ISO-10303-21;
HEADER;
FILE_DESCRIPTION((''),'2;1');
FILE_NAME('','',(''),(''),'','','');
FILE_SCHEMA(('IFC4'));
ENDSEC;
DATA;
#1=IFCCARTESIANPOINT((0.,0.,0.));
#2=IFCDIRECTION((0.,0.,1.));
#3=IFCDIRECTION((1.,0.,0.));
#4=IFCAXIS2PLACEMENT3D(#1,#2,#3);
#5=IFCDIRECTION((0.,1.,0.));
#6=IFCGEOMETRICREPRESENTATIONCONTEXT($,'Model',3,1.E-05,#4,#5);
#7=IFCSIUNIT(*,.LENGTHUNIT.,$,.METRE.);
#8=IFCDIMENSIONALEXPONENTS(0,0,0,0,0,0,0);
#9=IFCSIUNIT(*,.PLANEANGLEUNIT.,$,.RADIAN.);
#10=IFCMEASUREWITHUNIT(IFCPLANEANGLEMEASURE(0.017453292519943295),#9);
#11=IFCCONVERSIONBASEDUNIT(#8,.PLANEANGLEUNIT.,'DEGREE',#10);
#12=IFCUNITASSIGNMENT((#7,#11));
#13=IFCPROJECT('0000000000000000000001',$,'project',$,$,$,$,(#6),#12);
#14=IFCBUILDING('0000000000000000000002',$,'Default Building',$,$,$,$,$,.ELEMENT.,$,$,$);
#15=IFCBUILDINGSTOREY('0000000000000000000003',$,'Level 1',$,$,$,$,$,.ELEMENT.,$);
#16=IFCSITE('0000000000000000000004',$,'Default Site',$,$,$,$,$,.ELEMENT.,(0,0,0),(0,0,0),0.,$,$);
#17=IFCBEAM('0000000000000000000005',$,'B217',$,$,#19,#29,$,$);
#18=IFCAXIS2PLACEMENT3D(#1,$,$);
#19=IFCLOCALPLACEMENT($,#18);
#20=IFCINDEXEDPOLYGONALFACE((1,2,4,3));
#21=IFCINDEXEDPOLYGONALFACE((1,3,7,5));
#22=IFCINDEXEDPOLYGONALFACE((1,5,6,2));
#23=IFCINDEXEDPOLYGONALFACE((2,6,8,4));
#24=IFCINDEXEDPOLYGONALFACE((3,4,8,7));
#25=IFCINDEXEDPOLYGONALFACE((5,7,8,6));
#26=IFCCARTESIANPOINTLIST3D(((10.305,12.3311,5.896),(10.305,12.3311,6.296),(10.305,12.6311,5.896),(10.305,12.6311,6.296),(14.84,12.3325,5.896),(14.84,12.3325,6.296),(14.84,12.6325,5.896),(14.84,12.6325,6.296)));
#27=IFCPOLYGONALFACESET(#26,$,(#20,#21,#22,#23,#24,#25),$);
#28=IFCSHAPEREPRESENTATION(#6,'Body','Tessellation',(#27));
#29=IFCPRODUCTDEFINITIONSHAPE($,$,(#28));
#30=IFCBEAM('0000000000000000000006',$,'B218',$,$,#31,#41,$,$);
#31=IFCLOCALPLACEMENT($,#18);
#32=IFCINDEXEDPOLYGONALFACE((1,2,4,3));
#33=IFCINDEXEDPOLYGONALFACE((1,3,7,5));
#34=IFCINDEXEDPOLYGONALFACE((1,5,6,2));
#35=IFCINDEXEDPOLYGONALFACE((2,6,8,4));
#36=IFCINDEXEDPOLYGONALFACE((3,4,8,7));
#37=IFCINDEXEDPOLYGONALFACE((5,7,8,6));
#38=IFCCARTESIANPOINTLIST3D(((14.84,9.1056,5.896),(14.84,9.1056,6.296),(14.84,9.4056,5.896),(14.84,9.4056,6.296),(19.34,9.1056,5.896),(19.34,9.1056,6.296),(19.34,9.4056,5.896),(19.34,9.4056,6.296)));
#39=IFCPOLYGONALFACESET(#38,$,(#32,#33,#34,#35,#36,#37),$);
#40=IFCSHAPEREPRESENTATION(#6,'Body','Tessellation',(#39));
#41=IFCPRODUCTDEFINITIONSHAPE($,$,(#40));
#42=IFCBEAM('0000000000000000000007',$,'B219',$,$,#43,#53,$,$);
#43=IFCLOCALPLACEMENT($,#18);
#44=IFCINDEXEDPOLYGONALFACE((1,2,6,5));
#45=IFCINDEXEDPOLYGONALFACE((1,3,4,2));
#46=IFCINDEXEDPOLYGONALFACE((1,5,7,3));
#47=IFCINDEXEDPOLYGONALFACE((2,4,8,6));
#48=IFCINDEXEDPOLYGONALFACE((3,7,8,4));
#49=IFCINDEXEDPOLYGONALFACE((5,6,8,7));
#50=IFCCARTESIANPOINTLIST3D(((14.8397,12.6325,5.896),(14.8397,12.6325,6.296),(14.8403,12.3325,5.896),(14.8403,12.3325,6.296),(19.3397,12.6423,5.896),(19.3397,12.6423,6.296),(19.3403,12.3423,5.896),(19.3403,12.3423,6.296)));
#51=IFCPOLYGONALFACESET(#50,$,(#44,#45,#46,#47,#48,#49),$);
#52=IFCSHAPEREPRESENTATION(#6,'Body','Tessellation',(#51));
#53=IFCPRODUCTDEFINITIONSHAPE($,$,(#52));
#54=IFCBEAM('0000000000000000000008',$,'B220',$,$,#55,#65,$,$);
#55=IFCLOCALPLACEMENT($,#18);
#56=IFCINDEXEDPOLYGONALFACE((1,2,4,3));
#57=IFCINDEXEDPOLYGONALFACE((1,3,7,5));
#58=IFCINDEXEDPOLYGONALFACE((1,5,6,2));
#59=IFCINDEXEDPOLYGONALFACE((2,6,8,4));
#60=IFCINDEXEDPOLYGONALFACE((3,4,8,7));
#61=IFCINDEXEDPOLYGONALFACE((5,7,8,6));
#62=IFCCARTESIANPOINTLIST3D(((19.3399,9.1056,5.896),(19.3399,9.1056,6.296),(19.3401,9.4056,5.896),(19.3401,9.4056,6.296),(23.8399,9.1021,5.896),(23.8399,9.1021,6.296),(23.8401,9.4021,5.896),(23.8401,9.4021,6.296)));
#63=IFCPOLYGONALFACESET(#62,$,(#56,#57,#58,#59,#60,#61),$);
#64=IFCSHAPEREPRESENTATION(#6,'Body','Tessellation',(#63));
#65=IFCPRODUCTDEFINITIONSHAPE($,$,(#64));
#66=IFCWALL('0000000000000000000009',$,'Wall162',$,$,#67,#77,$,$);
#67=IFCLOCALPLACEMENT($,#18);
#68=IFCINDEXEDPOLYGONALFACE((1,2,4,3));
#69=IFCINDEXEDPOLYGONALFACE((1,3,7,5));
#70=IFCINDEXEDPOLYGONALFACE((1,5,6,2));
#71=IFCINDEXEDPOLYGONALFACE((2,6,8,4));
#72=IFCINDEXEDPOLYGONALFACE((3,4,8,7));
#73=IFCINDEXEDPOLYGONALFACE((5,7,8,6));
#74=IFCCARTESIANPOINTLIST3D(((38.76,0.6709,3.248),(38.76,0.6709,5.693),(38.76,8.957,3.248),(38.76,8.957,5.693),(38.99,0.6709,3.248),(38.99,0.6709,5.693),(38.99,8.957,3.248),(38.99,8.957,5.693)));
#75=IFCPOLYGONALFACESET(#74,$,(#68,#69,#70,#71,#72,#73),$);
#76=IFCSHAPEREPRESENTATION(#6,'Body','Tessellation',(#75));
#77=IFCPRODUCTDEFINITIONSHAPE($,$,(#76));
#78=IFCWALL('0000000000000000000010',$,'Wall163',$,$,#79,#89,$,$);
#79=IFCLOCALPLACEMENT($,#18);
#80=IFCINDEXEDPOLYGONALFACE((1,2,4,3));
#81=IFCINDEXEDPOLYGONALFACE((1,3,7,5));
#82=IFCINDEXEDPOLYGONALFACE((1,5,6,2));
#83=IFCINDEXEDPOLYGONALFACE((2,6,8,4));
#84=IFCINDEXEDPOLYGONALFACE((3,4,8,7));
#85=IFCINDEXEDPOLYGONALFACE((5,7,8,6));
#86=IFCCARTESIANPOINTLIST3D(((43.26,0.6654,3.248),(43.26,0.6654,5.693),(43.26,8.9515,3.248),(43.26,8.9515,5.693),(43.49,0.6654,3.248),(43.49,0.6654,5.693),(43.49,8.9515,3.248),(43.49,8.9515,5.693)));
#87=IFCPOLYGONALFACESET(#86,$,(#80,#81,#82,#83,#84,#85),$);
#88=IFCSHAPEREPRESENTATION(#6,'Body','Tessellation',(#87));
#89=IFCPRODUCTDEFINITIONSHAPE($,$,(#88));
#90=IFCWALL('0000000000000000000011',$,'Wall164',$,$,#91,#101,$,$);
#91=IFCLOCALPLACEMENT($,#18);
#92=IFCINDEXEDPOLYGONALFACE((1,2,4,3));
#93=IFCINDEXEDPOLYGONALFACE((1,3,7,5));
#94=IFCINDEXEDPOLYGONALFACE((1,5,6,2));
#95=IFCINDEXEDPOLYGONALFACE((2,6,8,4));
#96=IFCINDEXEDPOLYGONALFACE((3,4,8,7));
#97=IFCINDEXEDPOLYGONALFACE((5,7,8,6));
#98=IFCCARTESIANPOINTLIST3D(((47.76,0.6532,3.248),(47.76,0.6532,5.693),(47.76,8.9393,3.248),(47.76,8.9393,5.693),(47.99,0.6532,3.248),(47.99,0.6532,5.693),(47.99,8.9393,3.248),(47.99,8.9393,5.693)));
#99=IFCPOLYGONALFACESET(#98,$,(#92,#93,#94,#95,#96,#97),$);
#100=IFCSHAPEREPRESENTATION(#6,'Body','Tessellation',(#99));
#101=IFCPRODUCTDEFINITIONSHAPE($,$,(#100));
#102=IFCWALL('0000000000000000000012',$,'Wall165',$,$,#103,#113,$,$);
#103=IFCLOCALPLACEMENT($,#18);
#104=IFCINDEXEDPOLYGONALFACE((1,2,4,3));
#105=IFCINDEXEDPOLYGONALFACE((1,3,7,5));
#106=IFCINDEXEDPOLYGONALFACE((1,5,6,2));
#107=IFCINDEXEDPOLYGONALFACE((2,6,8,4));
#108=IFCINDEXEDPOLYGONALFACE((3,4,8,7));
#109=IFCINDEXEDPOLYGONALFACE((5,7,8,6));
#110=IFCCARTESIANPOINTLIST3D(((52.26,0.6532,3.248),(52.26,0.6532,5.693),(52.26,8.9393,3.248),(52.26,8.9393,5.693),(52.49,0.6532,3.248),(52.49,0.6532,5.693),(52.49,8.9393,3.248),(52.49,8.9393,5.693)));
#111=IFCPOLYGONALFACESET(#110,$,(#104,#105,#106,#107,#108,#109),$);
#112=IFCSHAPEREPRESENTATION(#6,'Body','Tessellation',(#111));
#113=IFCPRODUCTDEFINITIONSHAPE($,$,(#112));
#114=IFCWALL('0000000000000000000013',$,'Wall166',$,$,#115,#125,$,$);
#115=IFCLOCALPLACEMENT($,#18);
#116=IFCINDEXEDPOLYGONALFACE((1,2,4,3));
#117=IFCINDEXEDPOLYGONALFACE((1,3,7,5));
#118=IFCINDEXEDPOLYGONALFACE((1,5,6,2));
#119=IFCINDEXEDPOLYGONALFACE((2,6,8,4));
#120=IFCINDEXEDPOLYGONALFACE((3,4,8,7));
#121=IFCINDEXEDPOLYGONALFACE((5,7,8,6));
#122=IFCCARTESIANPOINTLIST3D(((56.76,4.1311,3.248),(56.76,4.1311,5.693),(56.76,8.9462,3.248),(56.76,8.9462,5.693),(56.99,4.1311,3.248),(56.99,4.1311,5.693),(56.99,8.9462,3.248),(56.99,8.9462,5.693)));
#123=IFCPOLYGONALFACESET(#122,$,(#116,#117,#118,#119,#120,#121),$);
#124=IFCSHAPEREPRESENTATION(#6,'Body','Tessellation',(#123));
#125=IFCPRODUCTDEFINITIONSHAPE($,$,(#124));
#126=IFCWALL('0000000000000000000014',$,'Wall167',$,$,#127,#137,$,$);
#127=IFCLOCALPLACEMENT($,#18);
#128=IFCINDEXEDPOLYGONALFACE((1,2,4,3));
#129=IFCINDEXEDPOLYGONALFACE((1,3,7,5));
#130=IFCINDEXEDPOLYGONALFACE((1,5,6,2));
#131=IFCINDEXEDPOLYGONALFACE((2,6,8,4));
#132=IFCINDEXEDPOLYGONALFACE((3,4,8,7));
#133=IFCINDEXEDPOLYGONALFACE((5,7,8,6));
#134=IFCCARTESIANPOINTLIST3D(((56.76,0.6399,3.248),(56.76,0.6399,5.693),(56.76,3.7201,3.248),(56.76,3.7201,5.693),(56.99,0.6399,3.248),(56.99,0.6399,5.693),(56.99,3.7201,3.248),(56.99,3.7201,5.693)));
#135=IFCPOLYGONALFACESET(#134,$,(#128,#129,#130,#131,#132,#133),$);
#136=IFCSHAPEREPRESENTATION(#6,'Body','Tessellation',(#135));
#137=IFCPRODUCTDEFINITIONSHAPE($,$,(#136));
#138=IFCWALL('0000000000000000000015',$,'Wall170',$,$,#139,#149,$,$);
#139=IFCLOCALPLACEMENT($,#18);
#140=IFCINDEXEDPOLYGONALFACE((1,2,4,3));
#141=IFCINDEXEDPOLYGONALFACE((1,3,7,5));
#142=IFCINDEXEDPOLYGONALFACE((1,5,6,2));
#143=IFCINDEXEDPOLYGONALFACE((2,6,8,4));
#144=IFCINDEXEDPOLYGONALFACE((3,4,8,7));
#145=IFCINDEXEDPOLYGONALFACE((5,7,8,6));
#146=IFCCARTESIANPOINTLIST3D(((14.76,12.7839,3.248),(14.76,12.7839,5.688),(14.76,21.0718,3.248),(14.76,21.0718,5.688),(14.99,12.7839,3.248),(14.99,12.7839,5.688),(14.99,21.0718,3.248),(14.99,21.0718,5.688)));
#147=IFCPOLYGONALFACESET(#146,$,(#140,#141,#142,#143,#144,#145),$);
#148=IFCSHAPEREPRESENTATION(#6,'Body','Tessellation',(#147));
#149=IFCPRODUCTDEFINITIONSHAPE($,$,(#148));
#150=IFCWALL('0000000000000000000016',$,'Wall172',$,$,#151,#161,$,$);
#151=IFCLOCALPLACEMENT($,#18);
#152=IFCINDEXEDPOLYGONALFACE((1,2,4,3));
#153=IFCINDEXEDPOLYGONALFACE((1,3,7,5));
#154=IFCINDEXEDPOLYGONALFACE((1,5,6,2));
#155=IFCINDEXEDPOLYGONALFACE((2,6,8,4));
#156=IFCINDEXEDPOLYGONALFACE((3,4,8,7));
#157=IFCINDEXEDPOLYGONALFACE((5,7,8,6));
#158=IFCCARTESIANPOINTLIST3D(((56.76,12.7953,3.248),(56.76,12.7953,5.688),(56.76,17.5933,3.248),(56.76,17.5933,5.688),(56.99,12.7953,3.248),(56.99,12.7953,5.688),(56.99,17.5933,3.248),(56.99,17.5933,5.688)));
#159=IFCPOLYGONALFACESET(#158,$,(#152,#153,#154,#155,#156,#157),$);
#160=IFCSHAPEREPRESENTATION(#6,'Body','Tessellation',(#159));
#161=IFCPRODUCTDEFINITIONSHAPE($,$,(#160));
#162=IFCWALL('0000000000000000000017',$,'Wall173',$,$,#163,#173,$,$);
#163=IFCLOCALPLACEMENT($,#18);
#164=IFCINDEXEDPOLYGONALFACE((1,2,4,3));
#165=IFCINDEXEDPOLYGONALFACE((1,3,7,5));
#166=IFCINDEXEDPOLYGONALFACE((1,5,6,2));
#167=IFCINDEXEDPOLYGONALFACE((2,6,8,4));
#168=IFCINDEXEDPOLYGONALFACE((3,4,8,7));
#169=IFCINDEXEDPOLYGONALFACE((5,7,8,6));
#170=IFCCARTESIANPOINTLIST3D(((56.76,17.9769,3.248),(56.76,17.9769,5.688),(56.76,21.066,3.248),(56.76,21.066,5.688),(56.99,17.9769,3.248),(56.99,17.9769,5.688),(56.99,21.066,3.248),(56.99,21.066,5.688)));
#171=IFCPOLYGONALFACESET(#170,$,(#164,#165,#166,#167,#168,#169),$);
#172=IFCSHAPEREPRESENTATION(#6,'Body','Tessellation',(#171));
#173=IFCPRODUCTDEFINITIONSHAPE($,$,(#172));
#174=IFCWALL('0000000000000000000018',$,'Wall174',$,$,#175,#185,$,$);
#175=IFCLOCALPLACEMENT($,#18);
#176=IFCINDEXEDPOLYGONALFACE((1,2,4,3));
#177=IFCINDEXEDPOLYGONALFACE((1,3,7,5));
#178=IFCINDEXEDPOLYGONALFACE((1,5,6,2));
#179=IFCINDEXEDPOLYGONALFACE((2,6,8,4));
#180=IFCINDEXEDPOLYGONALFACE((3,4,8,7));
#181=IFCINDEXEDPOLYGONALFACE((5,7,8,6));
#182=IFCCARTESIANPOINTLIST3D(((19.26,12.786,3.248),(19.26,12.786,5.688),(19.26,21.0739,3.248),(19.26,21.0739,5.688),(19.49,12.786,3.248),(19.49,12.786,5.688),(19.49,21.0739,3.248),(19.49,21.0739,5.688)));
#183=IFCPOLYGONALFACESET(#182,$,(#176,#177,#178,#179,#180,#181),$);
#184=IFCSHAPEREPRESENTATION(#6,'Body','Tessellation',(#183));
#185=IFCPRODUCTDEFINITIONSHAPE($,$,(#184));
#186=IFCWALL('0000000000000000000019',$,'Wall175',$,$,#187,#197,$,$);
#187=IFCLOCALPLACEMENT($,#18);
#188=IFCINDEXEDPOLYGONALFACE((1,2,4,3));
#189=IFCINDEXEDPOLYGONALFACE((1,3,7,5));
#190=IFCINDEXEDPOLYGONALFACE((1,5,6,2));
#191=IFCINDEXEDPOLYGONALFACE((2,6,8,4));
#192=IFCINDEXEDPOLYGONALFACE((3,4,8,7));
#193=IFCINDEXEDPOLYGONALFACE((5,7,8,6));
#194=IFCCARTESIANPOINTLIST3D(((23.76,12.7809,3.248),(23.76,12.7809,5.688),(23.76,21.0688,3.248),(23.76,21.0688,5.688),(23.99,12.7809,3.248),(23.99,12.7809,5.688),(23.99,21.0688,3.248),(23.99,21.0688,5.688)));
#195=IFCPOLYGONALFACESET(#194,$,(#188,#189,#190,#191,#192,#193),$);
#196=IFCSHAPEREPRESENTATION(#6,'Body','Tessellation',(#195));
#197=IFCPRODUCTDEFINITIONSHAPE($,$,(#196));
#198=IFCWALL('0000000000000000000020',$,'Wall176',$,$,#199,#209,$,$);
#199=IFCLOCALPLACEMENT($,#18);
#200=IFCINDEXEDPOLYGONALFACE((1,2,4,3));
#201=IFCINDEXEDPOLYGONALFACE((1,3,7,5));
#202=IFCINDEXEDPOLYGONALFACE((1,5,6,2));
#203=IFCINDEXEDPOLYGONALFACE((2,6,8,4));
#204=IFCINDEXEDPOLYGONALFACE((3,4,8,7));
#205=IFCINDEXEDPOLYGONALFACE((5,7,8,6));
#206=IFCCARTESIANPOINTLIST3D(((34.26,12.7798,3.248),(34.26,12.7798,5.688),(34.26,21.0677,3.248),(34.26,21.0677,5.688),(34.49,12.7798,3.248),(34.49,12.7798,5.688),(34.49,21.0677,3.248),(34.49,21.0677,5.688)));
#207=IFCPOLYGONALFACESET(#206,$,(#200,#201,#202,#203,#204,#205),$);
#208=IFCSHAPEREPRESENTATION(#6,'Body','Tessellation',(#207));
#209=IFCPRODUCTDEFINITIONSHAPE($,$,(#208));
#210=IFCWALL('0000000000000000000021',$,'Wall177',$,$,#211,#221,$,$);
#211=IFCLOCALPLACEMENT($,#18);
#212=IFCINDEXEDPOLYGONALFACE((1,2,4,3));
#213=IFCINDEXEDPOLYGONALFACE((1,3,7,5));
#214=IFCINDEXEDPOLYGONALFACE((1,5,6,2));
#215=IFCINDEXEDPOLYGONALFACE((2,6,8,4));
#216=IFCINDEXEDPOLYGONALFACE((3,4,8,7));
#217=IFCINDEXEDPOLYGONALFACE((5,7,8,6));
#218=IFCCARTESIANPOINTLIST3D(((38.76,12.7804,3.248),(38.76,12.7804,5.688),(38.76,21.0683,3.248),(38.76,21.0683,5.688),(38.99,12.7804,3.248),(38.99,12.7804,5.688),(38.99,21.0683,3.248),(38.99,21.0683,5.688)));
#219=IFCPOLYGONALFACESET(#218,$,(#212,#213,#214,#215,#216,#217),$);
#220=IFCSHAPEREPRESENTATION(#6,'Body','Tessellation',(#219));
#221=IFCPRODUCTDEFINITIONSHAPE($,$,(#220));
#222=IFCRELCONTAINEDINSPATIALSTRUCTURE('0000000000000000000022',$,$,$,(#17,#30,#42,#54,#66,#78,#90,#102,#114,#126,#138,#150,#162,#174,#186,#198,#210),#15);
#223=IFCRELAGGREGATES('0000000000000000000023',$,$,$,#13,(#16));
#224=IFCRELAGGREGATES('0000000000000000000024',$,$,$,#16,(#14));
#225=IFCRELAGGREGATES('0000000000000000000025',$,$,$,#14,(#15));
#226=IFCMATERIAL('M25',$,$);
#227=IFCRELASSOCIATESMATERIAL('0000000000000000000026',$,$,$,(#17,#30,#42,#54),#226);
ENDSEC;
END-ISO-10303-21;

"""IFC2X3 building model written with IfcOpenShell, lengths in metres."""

from ifc_helpers import new_model, entity, si_unit, converted_unit, direction, frame, frame_2d, origin_with_axes, place, context, project, spatial, rectangle, extrude, material, element, save


model = new_model("IFC2X3")

# Units and contexts
model_context = context("Model", 3, precision=1e-05, world=origin_with_axes(), true_north=direction((0.0, 1.0, 0.0)))
ifc_project = project(units=[si_unit("LENGTHUNIT", "METRE"), converted_unit("PLANEANGLEUNIT", "DEGREE", entity("IfcPlaneAngleMeasure", 0.017453292519943295), si_unit("PLANEANGLEUNIT", "RADIAN"), dimensions=[0, 0, 0, 0, 0, 0, 0])], contexts=[model_context])

# Site, building, storey
site = spatial("IfcSite", under=ifc_project, Name="Default Site", CompositionType="ELEMENT", RefLatitude=(0, 0, 0), RefLongitude=(0, 0, 0), RefElevation=0.0)
building = spatial("IfcBuilding", under=site, Name="Default Building", CompositionType="ELEMENT")
storey = spatial("IfcBuildingStorey", under=building, Name="Level 1", CompositionType="ELEMENT")

# Beams
ifc_material = material(Name="M25")
placement = place(None, origin_with_axes())
element("IfcBeam", 1, at=placement, inside=storey, material=ifc_material, Name="B217", context=model_context, shape_type="SweptSolid", body=[
    extrude(rectangle(XDim=0.3, YDim=0.4, at=frame_2d((0.0, 0.0), x_axis=(0.0, 1.0, 0.0))), frame((10.305, 12.4811, 6.096), z_axis=(1.0, 0.000301, 0.0), x_axis=(0.0, 0.0, -1.0)), (0.0, 0.0, 1.0), 4.535),
])
element("IfcBeam", 2, at=placement, inside=storey, material=ifc_material, Name="B218", context=model_context, shape_type="SweptSolid", body=[
    extrude(rectangle(XDim=0.3, YDim=0.4, at=frame_2d((0.0, 0.0), x_axis=(0.0, 1.0, 0.0))), frame((14.84, 9.2556, 6.096), z_axis=(1.0, 0.000013, 0.0), x_axis=(0.0, 0.0, -1.0)), (0.0, 0.0, 1.0), 4.5),
])
element("IfcBeam", 3, at=placement, inside=storey, material=ifc_material, Name="B219", context=model_context, shape_type="SweptSolid", body=[
    extrude(rectangle(XDim=0.3, YDim=0.4, at=frame_2d((0.0, 0.0), x_axis=(0.0, 1.0, 0.0))), frame((14.84, 12.4825, 6.096), z_axis=(0.999998, 0.002176, 0.0), x_axis=(0.0, 0.0, -1.0)), (0.0, 0.0, 1.0), 4.5),
])
element("IfcBeam", 4, at=placement, inside=storey, material=ifc_material, Name="B220", context=model_context, shape_type="SweptSolid", body=[
    extrude(rectangle(XDim=0.3, YDim=0.4, at=frame_2d((0.0, 0.0), x_axis=(0.0, 1.0, 0.0))), frame((19.34, 9.2556, 6.096), z_axis=(1.0, -0.000779, 0.0), x_axis=(0.0, 0.0, -1.0)), (0.0, 0.0, 1.0), 4.5),
])

# Walls
element("IfcWall", 5, at=placement, inside=storey, Name="Wall162", context=model_context, shape_type="SweptSolid", body=[
    extrude(rectangle(XDim=8.2861, YDim=0.23, at=frame_2d((0.0, 0.0), x_axis=(0.0, 1.0, 0.0))), frame((38.875, 4.8139, 3.248), z_axis=(0.0, 0.0, 1.0), x_axis=(1.0, 0.0, 0.0)), (0.0, 0.0, 1.0), 2.445),
])
element("IfcWall", 6, at=placement, inside=storey, Name="Wall163", context=model_context, shape_type="SweptSolid", body=[
    extrude(rectangle(XDim=8.2861, YDim=0.23, at=frame_2d((0.0, 0.0), x_axis=(0.0, 1.0, 0.0))), frame((43.375, 4.8084, 3.248), z_axis=(0.0, 0.0, 1.0), x_axis=(1.0, 0.0, 0.0)), (0.0, 0.0, 1.0), 2.445),
])
element("IfcWall", 7, at=placement, inside=storey, Name="Wall164", context=model_context, shape_type="SweptSolid", body=[
    extrude(rectangle(XDim=8.2861, YDim=0.23, at=frame_2d((0.0, 0.0), x_axis=(0.0, 1.0, 0.0))), frame((47.875, 4.7963, 3.248), z_axis=(0.0, 0.0, 1.0), x_axis=(1.0, 0.0, 0.0)), (0.0, 0.0, 1.0), 2.445),
])
element("IfcWall", 8, at=placement, inside=storey, Name="Wall165", context=model_context, shape_type="SweptSolid", body=[
    extrude(rectangle(XDim=8.2861, YDim=0.23, at=frame_2d((0.0, 0.0), x_axis=(0.0, 1.0, 0.0))), frame((52.375, 4.7963, 3.248), z_axis=(0.0, 0.0, 1.0), x_axis=(1.0, 0.0, 0.0)), (0.0, 0.0, 1.0), 2.445),
])
element("IfcWall", 9, at=placement, inside=storey, Name="Wall166", context=model_context, shape_type="SweptSolid", body=[
    extrude(rectangle(XDim=4.8151, YDim=0.23, at=frame_2d((0.0, 0.0), x_axis=(0.0, -1.0, 0.0))), frame((56.875, 6.5387, 3.248), z_axis=(0.0, 0.0, 1.0), x_axis=(1.0, 0.0, 0.0)), (0.0, 0.0, 1.0), 2.445),
])
element("IfcWall", 10, at=placement, inside=storey, Name="Wall167", context=model_context, shape_type="SweptSolid", body=[
    extrude(rectangle(XDim=3.0802, YDim=0.23, at=frame_2d((0.0, 0.0), x_axis=(0.0, -1.0, 0.0))), frame((56.875, 2.18, 3.248), z_axis=(0.0, 0.0, 1.0), x_axis=(1.0, 0.0, 0.0)), (0.0, 0.0, 1.0), 2.445),
])
element("IfcWall", 11, at=placement, inside=storey, Name="Wall170", context=model_context, shape_type="SweptSolid", body=[
    extrude(rectangle(XDim=8.2879, YDim=0.23, at=frame_2d((0.0, 0.0), x_axis=(0.0, 1.0, 0.0))), frame((14.875, 16.9278, 3.248), z_axis=(0.0, 0.0, 1.0), x_axis=(1.0, 0.0, 0.0)), (0.0, 0.0, 1.0), 2.44),
])
element("IfcWall", 12, at=placement, inside=storey, Name="Wall172", context=model_context, shape_type="SweptSolid", body=[
    extrude(rectangle(XDim=4.798, YDim=0.23, at=frame_2d((0.0, 0.0), x_axis=(0.0, -1.0, 0.0))), frame((56.875, 15.1943, 3.248), z_axis=(0.0, 0.0, 1.0), x_axis=(1.0, 0.0, 0.0)), (0.0, 0.0, 1.0), 2.44),
])
element("IfcWall", 13, at=placement, inside=storey, Name="Wall173", context=model_context, shape_type="SweptSolid", body=[
    extrude(rectangle(XDim=3.0891, YDim=0.23, at=frame_2d((0.0, 0.0), x_axis=(0.0, -1.0, 0.0))), frame((56.875, 19.5215, 3.248), z_axis=(0.0, 0.0, 1.0), x_axis=(1.0, 0.0, 0.0)), (0.0, 0.0, 1.0), 2.44),
])
element("IfcWall", 14, at=placement, inside=storey, Name="Wall174", context=model_context, shape_type="SweptSolid", body=[
    extrude(rectangle(XDim=8.2879, YDim=0.23, at=frame_2d((0.0, 0.0), x_axis=(0.0, 1.0, 0.0))), frame((19.375, 16.9299, 3.248), z_axis=(0.0, 0.0, 1.0), x_axis=(1.0, 0.0, 0.0)), (0.0, 0.0, 1.0), 2.44),
])
element("IfcWall", 15, at=placement, inside=storey, Name="Wall175", context=model_context, shape_type="SweptSolid", body=[
    extrude(rectangle(XDim=8.2879, YDim=0.23, at=frame_2d((0.0, 0.0), x_axis=(0.0, 1.0, 0.0))), frame((23.875, 16.9248, 3.248), z_axis=(0.0, 0.0, 1.0), x_axis=(1.0, 0.0, 0.0)), (0.0, 0.0, 1.0), 2.44),
])
element("IfcWall", 16, at=placement, inside=storey, Name="Wall176", context=model_context, shape_type="SweptSolid", body=[
    extrude(rectangle(XDim=8.2879, YDim=0.23, at=frame_2d((0.0, 0.0), x_axis=(0.0, 1.0, 0.0))), frame((34.375, 16.9238, 3.248), z_axis=(0.0, 0.0, 1.0), x_axis=(1.0, 0.0, 0.0)), (0.0, 0.0, 1.0), 2.44),
])
element("IfcWall", 17, at=placement, inside=storey, Name="Wall177", context=model_context, shape_type="SweptSolid", body=[
    extrude(rectangle(XDim=8.2879, YDim=0.23, at=frame_2d((0.0, 0.0), x_axis=(0.0, 1.0, 0.0))), frame((38.875, 16.9244, 3.248), z_axis=(0.0, 0.0, 1.0), x_axis=(1.0, 0.0, 0.0)), (0.0, 0.0, 1.0), 2.44),
])

save(model, "model.ifc")
